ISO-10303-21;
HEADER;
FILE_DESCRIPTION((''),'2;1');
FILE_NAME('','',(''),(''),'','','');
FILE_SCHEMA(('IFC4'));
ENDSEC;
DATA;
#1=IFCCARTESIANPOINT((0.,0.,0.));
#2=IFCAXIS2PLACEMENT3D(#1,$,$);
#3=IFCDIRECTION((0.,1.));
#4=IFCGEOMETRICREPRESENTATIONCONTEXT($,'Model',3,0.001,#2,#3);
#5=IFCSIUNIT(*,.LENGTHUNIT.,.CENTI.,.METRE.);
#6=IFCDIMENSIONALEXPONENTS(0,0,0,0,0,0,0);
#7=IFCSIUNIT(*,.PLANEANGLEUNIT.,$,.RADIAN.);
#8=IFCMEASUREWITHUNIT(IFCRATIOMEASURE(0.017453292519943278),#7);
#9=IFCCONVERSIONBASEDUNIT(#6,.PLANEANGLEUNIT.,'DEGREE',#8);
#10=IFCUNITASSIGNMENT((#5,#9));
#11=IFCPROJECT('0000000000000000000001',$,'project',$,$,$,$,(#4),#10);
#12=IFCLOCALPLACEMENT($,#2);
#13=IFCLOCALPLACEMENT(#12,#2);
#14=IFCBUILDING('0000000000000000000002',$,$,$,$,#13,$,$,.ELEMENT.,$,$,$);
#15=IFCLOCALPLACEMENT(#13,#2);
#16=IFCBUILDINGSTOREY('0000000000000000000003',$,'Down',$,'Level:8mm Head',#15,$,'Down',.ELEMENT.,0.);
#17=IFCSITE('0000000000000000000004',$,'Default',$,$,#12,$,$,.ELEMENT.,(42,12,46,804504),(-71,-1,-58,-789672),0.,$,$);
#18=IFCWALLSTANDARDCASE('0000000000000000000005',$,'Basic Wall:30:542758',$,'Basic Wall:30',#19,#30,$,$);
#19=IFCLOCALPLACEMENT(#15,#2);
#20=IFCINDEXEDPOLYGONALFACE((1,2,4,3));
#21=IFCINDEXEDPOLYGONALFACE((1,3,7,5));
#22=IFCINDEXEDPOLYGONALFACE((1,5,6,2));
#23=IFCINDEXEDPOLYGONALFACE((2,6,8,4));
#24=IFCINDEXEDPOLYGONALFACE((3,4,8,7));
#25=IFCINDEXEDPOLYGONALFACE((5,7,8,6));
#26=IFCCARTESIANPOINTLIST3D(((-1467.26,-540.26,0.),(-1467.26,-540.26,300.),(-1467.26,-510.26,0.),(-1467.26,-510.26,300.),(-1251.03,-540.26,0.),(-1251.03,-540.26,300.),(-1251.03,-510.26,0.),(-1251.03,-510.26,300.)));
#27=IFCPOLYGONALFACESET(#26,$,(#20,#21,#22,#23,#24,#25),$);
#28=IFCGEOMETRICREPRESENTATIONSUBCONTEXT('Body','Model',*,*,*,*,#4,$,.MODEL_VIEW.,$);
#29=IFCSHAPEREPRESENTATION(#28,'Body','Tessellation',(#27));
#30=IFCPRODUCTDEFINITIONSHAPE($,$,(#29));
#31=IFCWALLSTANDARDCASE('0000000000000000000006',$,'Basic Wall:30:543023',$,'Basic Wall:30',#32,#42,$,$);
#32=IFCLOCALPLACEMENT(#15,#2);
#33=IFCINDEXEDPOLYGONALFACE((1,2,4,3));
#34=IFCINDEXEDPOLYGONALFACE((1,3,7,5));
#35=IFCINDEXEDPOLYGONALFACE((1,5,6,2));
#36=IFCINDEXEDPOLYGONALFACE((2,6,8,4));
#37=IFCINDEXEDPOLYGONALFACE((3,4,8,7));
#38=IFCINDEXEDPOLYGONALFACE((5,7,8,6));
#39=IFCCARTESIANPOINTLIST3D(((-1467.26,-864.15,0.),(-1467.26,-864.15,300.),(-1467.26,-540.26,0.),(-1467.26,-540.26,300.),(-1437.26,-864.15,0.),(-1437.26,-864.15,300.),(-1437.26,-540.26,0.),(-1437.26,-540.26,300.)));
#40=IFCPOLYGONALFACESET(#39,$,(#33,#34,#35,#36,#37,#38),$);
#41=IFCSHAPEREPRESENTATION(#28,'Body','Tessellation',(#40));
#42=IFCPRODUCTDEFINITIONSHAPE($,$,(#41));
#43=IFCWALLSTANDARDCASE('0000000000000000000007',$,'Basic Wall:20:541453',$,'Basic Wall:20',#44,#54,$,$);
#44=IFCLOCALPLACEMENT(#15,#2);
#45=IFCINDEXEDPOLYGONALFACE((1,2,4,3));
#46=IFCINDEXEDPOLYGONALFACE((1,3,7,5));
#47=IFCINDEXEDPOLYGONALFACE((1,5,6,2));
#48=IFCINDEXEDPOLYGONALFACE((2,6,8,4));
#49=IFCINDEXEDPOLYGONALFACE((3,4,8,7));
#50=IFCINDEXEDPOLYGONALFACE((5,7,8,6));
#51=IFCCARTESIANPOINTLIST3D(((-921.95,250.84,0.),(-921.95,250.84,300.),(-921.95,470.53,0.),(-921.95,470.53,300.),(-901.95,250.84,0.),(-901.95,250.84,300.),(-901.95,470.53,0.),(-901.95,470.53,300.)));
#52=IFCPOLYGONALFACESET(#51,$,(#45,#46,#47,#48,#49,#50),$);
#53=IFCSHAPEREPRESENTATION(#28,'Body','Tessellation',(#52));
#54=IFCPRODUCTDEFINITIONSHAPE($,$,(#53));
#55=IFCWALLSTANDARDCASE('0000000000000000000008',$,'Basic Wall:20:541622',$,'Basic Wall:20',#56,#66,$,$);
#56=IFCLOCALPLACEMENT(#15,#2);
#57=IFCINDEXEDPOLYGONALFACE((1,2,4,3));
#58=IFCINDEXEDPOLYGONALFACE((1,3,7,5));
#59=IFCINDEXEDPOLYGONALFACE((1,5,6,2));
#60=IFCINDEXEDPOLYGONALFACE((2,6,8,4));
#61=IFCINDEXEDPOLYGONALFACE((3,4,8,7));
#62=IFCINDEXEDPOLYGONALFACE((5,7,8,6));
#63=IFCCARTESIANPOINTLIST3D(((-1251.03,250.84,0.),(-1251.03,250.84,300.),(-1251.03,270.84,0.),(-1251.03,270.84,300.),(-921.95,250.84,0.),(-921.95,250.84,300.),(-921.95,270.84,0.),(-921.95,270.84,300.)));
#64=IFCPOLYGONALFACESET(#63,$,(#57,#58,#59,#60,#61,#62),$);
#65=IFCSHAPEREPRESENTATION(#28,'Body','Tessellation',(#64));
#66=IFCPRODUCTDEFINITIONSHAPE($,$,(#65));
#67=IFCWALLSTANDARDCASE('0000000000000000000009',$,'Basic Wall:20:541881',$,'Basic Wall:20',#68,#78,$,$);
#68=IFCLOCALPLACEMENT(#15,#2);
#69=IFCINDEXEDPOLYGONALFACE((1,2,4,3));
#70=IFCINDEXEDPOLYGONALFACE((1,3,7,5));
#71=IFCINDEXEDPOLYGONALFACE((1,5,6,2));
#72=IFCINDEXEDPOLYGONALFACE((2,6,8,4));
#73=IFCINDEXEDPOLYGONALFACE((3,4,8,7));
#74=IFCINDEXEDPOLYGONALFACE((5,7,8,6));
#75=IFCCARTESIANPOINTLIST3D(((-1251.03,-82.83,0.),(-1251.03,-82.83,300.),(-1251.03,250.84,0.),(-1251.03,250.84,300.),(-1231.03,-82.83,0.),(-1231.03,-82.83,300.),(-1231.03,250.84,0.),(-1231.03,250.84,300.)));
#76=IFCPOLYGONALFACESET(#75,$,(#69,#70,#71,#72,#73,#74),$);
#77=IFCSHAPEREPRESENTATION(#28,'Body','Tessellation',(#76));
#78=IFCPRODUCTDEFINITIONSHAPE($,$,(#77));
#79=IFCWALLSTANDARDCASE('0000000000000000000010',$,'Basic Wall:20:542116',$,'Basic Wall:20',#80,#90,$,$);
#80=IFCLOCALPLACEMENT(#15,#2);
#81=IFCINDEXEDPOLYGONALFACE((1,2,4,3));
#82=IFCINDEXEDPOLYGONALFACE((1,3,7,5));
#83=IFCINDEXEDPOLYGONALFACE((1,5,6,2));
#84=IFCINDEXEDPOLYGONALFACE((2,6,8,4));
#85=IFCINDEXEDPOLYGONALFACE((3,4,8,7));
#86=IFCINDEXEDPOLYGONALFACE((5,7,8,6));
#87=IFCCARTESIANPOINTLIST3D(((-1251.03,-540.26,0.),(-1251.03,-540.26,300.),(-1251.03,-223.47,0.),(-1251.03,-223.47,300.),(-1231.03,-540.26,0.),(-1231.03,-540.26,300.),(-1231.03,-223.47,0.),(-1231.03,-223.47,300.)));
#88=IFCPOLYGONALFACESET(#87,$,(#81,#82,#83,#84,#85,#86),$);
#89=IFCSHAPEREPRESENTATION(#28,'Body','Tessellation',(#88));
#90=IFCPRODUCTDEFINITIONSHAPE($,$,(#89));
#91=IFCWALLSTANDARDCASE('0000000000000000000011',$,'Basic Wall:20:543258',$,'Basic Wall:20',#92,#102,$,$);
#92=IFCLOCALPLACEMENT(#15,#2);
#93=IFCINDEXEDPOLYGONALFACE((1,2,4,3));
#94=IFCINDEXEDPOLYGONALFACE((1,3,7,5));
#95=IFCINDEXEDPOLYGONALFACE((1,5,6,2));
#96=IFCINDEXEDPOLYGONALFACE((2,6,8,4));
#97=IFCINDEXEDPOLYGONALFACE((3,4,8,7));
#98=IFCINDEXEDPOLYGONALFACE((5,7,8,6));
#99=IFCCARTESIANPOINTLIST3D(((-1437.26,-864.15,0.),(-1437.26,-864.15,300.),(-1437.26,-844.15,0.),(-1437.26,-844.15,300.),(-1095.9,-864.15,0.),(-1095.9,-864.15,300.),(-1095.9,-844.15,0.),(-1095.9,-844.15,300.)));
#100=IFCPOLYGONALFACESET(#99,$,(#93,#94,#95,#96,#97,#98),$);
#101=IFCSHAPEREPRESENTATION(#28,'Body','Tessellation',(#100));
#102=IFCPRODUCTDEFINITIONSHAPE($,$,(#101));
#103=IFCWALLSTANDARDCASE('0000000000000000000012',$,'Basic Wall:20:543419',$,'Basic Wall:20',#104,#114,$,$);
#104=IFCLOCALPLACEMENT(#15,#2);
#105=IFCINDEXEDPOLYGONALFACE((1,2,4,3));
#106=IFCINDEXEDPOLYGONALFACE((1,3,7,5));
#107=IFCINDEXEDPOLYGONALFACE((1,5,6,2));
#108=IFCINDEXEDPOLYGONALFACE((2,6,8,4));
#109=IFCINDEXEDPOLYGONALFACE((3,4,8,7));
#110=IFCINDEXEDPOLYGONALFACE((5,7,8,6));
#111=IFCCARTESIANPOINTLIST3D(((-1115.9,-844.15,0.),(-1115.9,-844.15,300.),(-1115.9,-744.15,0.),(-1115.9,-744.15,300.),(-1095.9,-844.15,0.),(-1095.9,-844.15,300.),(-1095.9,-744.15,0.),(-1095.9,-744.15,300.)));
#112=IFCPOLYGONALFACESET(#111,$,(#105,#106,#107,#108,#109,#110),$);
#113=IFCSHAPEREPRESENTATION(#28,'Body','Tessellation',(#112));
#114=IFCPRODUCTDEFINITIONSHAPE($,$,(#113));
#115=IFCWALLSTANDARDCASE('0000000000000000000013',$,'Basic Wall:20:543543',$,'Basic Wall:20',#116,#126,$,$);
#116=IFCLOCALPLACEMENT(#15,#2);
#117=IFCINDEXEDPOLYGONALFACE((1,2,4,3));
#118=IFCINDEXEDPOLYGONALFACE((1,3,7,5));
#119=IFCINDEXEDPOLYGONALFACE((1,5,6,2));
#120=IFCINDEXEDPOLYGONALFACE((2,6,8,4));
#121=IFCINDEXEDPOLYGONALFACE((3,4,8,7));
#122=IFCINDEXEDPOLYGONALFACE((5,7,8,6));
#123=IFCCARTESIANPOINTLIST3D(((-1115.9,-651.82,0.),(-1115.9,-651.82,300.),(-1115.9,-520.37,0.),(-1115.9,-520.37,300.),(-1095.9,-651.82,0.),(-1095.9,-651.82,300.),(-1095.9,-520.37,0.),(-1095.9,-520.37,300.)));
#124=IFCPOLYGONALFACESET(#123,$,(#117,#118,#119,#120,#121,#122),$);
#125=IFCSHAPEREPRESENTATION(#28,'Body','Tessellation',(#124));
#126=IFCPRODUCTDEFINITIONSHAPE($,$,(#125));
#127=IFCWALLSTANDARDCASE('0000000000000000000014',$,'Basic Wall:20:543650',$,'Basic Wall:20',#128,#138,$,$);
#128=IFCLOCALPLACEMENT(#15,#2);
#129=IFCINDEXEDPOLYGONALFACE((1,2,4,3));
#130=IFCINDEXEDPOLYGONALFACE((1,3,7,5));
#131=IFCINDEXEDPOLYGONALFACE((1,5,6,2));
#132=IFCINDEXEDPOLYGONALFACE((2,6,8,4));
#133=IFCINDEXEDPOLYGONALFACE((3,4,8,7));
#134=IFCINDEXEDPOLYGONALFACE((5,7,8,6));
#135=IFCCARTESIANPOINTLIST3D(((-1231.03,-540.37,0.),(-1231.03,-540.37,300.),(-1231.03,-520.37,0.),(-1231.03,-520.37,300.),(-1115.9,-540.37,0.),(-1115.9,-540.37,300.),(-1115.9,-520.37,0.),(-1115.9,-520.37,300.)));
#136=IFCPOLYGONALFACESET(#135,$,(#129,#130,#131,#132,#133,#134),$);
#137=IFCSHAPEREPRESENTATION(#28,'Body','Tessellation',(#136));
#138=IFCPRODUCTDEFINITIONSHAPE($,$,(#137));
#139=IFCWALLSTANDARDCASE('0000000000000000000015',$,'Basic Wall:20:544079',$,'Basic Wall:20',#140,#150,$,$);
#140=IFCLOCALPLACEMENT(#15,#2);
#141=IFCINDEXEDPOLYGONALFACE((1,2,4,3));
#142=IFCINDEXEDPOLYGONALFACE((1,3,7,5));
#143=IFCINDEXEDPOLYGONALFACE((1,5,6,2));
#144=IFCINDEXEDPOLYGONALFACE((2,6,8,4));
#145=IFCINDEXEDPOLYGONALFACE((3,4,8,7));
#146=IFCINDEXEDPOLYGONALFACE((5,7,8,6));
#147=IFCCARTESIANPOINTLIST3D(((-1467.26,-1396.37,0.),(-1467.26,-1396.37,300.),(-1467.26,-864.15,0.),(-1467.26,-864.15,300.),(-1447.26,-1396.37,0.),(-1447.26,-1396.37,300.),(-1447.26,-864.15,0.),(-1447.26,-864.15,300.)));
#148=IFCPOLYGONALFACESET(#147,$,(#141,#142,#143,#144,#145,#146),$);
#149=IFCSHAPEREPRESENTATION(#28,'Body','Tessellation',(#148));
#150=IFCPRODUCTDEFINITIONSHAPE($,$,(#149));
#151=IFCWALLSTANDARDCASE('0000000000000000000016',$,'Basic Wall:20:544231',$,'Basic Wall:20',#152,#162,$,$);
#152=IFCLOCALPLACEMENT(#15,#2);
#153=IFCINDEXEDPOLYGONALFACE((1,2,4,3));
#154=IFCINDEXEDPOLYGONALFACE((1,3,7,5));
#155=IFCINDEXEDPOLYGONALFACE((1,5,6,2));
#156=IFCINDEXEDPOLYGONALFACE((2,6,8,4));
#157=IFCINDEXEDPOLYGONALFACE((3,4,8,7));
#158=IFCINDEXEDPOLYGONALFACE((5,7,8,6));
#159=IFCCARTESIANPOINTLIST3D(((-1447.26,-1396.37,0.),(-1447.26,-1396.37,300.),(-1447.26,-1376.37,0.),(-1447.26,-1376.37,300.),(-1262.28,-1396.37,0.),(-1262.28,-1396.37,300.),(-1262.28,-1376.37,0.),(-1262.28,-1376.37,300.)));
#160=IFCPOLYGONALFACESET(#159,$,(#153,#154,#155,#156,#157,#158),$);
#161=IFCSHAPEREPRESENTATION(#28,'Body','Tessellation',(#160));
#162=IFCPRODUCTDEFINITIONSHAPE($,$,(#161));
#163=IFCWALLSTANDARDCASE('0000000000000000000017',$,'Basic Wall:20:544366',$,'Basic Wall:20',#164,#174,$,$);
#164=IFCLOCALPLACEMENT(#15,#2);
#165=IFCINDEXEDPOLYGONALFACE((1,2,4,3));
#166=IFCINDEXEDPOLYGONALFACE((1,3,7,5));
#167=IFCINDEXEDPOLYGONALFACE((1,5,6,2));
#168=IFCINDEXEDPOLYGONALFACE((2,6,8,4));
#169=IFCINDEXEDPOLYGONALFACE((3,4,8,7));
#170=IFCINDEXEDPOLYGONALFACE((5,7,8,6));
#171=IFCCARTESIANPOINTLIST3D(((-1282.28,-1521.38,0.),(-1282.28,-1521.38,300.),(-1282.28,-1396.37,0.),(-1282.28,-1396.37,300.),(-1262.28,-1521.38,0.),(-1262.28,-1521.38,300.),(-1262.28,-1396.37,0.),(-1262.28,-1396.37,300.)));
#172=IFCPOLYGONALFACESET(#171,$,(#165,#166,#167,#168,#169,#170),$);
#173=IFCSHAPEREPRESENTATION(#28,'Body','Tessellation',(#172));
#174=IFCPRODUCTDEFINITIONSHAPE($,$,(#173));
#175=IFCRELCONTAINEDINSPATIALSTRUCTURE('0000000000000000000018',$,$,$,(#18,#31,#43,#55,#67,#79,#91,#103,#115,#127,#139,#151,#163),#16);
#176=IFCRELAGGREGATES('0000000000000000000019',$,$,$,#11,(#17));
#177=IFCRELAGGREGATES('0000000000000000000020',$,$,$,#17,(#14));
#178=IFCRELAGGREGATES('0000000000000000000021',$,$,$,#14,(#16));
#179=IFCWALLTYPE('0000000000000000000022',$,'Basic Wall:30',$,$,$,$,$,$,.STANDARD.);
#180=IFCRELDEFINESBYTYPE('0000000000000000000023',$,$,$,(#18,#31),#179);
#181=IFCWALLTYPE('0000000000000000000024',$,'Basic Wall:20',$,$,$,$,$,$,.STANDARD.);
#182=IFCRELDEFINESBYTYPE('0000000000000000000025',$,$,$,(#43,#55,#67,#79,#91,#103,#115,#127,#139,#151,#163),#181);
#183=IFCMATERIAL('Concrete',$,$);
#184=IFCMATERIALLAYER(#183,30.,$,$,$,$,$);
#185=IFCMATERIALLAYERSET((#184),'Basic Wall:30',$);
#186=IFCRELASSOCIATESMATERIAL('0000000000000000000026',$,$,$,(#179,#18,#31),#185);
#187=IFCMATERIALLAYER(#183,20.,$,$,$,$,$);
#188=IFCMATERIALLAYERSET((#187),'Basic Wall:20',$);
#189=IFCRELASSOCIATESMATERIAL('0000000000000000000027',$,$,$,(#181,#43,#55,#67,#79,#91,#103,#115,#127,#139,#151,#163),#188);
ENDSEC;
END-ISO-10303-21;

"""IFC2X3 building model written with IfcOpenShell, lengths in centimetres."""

from ifc_helpers import new_model, entity, si_unit, converted_unit, direction, frame, frame_2d, origin, place, context, subcontext, project, spatial, rectangle, extrude, material, layer, layer_set, layer_usage, type_object, element, save


model = new_model("IFC2X3")

# Units and contexts
model_context = context("Model", 3, precision=0.001, world=origin(), true_north=direction((0.0, 1.0)))
body_context = subcontext(model_context, "Body", "Model", "MODEL_VIEW")
ifc_project = project(units=[si_unit("LENGTHUNIT", "METRE", prefix="CENTI"), converted_unit("PLANEANGLEUNIT", "DEGREE", entity("IfcRatioMeasure", 0.017453292519943278), si_unit("PLANEANGLEUNIT", "RADIAN"), dimensions=[0, 0, 0, 0, 0, 0, 0])], contexts=[model_context])

# Site, building, storey
site_placement = place(None, origin())
site = spatial("IfcSite", under=ifc_project, at=site_placement, Name="Default", CompositionType="ELEMENT", RefLatitude=(42, 12, 46, 804504), RefLongitude=(-71, -1, -58, -789672), RefElevation=0.0)
building_placement = place(site_placement, origin())
building = spatial("IfcBuilding", under=site, at=building_placement, CompositionType="ELEMENT")
storey_placement = place(building_placement, origin())
storey = spatial("IfcBuildingStorey", under=building, at=storey_placement, Name="Down", ObjectType="Level:8mm Head", LongName="Down", CompositionType="ELEMENT", Elevation=0.0)

# Walls
ifc_material = material(Name="Concrete")
ifc_layer_1 = layer(ifc_material, 30.0)
ifc_layer_set_1 = layer_set([ifc_layer_1], Name="Basic Wall:30")
ifc_layer_usage_1 = layer_usage(ifc_layer_set_1, "AXIS2", "NEGATIVE", 15.0)
wall_type_1 = type_object("IfcWallType", Name="Basic Wall:30", PredefinedType="STANDARD", material=ifc_layer_set_1)
wall_1_placement = place(storey_placement, frame((-1467.26, -525.26, 0.0)))
element("IfcWallStandardCase", 1, at=wall_1_placement, inside=storey, type_object=wall_type_1, material=ifc_layer_usage_1, Name="Basic Wall:30:542758", ObjectType="Basic Wall:30", context=body_context, shape_type="SweptSolid", body=[
    extrude(rectangle(XDim=216.23, YDim=30.0, at=frame_2d((108.12, 0.0), x_axis=(-1.0, 0.0))), origin(), (0.0, 0.0, 1.0), 300.0),
])
ifc_layer_usage_2 = layer_usage(ifc_layer_set_1, "AXIS2", "POSITIVE", -15.0)
wall_2_placement = place(storey_placement, frame((-1452.26, -540.26, 0.0), z_axis=(0.0, 0.0, 1.0), x_axis=(0.0, -1.0, 0.0)))
element("IfcWallStandardCase", 2, at=wall_2_placement, inside=storey, type_object=wall_type_1, material=ifc_layer_usage_2, Name="Basic Wall:30:543023", ObjectType="Basic Wall:30", context=body_context, shape_type="SweptSolid", body=[
    extrude(rectangle(XDim=323.89, YDim=30.0, at=frame_2d((161.95, 0.0), x_axis=(-1.0, 0.0))), origin(), (0.0, 0.0, 1.0), 300.0),
])
ifc_layer_2 = layer(ifc_material, 20.0)
ifc_layer_set_2 = layer_set([ifc_layer_2], Name="Basic Wall:20")
ifc_layer_usage_3 = layer_usage(ifc_layer_set_2, "AXIS2", "NEGATIVE", 10.0)
wall_type_2 = type_object("IfcWallType", Name="Basic Wall:20", PredefinedType="STANDARD", material=ifc_layer_set_2)
wall_3_placement = place(storey_placement, frame((-911.95, 470.53, 0.0), z_axis=(0.0, 0.0, 1.0), x_axis=(0.0, -1.0, 0.0)))
element("IfcWallStandardCase", 3, at=wall_3_placement, inside=storey, type_object=wall_type_2, material=ifc_layer_usage_3, Name="Basic Wall:20:541453", ObjectType="Basic Wall:20", context=body_context, shape_type="SweptSolid", body=[
    extrude(rectangle(XDim=219.69, YDim=20.0, at=frame_2d((109.84, 0.0), x_axis=(-1.0, 0.0))), origin(), (0.0, 0.0, 1.0), 300.0),
])
ifc_layer_usage_4 = layer_usage(ifc_layer_set_2, "AXIS2", "NEGATIVE", 10.0)
wall_4_placement = place(storey_placement, frame((-921.95, 260.84, 0.0), z_axis=(0.0, 0.0, 1.0), x_axis=(-1.0, 0.0, 0.0)))
element("IfcWallStandardCase", 4, at=wall_4_placement, inside=storey, type_object=wall_type_2, material=ifc_layer_usage_4, Name="Basic Wall:20:541622", ObjectType="Basic Wall:20", context=body_context, shape_type="SweptSolid", body=[
    extrude(rectangle(XDim=329.07, YDim=20.0, at=frame_2d((164.54, 0.0), x_axis=(-1.0, 0.0))), origin(), (0.0, 0.0, 1.0), 300.0),
])
ifc_layer_usage_5 = layer_usage(ifc_layer_set_2, "AXIS2", "POSITIVE", -10.0)
wall_5_placement = place(storey_placement, frame((-1241.03, 250.84, 0.0), z_axis=(0.0, 0.0, 1.0), x_axis=(0.0, -1.0, 0.0)))
element("IfcWallStandardCase", 5, at=wall_5_placement, inside=storey, type_object=wall_type_2, material=ifc_layer_usage_5, Name="Basic Wall:20:541881", ObjectType="Basic Wall:20", context=body_context, shape_type="SweptSolid", body=[
    extrude(rectangle(XDim=333.67, YDim=20.0, at=frame_2d((166.84, 0.0), x_axis=(-1.0, 0.0))), origin(), (0.0, 0.0, 1.0), 300.0),
])
ifc_layer_usage_6 = layer_usage(ifc_layer_set_2, "AXIS2", "POSITIVE", -10.0)
wall_6_placement = place(storey_placement, frame((-1241.03, -223.47, 0.0), z_axis=(0.0, 0.0, 1.0), x_axis=(0.0, -1.0, 0.0)))
element("IfcWallStandardCase", 6, at=wall_6_placement, inside=storey, type_object=wall_type_2, material=ifc_layer_usage_6, Name="Basic Wall:20:542116", ObjectType="Basic Wall:20", context=body_context, shape_type="SweptSolid", body=[
    extrude(rectangle(XDim=316.79, YDim=20.0, at=frame_2d((158.4, 0.0), x_axis=(-1.0, 0.0))), origin(), (0.0, 0.0, 1.0), 300.0),
])
ifc_layer_usage_7 = layer_usage(ifc_layer_set_2, "AXIS2", "POSITIVE", -10.0)
wall_7_placement = place(storey_placement, frame((-1437.26, -854.15, 0.0)))
element("IfcWallStandardCase", 7, at=wall_7_placement, inside=storey, type_object=wall_type_2, material=ifc_layer_usage_7, Name="Basic Wall:20:543258", ObjectType="Basic Wall:20", context=body_context, shape_type="SweptSolid", body=[
    extrude(rectangle(XDim=341.36, YDim=20.0, at=frame_2d((170.68, 0.0), x_axis=(-1.0, 0.0))), origin(), (0.0, 0.0, 1.0), 300.0),
])
ifc_layer_usage_8 = layer_usage(ifc_layer_set_2, "AXIS2", "POSITIVE", -10.0)
wall_8_placement = place(storey_placement, frame((-1105.9, -844.15, 0.0), z_axis=(0.0, 0.0, 1.0), x_axis=(0.0, 1.0, 0.0)))
element("IfcWallStandardCase", 8, at=wall_8_placement, inside=storey, type_object=wall_type_2, material=ifc_layer_usage_8, Name="Basic Wall:20:543419", ObjectType="Basic Wall:20", context=body_context, shape_type="SweptSolid", body=[
    extrude(rectangle(XDim=100.0, YDim=20.0, at=frame_2d((50.0, 0.0), x_axis=(-1.0, 0.0))), origin(), (0.0, 0.0, 1.0), 300.0),
])
ifc_layer_usage_9 = layer_usage(ifc_layer_set_2, "AXIS2", "POSITIVE", -10.0)
wall_9_placement = place(storey_placement, frame((-1105.9, -651.82, 0.0), z_axis=(0.0, 0.0, 1.0), x_axis=(0.0, 1.0, 0.0)))
element("IfcWallStandardCase", 9, at=wall_9_placement, inside=storey, type_object=wall_type_2, material=ifc_layer_usage_9, Name="Basic Wall:20:543543", ObjectType="Basic Wall:20", context=body_context, shape_type="SweptSolid", body=[
    extrude(rectangle(XDim=131.45, YDim=20.0, at=frame_2d((65.72, 0.0), x_axis=(-1.0, 0.0))), origin(), (0.0, 0.0, 1.0), 300.0),
])
ifc_layer_usage_10 = layer_usage(ifc_layer_set_2, "AXIS2", "POSITIVE", -10.0)
wall_10_placement = place(storey_placement, frame((-1115.9, -530.37, 0.0), z_axis=(0.0, 0.0, 1.0), x_axis=(-1.0, 0.0, 0.0)))
element("IfcWallStandardCase", 10, at=wall_10_placement, inside=storey, type_object=wall_type_2, material=ifc_layer_usage_10, Name="Basic Wall:20:543650", ObjectType="Basic Wall:20", context=body_context, shape_type="SweptSolid", body=[
    extrude(rectangle(XDim=115.12, YDim=20.0, at=frame_2d((57.56, 0.0), x_axis=(-1.0, 0.0))), origin(), (0.0, 0.0, 1.0), 300.0),
])
ifc_layer_usage_11 = layer_usage(ifc_layer_set_2, "AXIS2", "POSITIVE", -10.0)
wall_11_placement = place(storey_placement, frame((-1457.26, -864.15, 0.0), z_axis=(0.0, 0.0, 1.0), x_axis=(0.0, -1.0, 0.0)))
element("IfcWallStandardCase", 11, at=wall_11_placement, inside=storey, type_object=wall_type_2, material=ifc_layer_usage_11, Name="Basic Wall:20:544079", ObjectType="Basic Wall:20", context=body_context, shape_type="SweptSolid", body=[
    extrude(rectangle(XDim=532.22, YDim=20.0, at=frame_2d((266.11, 0.0), x_axis=(-1.0, 0.0))), origin(), (0.0, 0.0, 1.0), 300.0),
])
ifc_layer_usage_12 = layer_usage(ifc_layer_set_2, "AXIS2", "POSITIVE", -10.0)
wall_12_placement = place(storey_placement, frame((-1447.26, -1386.37, 0.0)))
element("IfcWallStandardCase", 12, at=wall_12_placement, inside=storey, type_object=wall_type_2, material=ifc_layer_usage_12, Name="Basic Wall:20:544231", ObjectType="Basic Wall:20", context=body_context, shape_type="SweptSolid", body=[
    extrude(rectangle(XDim=184.98, YDim=20.0, at=frame_2d((92.49, 0.0), x_axis=(-1.0, 0.0))), origin(), (0.0, 0.0, 1.0), 300.0),
])
ifc_layer_usage_13 = layer_usage(ifc_layer_set_2, "AXIS2", "NEGATIVE", 10.0)
wall_13_placement = place(storey_placement, frame((-1272.28, -1396.37, 0.0), z_axis=(0.0, 0.0, 1.0), x_axis=(0.0, -1.0, 0.0)))
element("IfcWallStandardCase", 13, at=wall_13_placement, inside=storey, type_object=wall_type_2, material=ifc_layer_usage_13, Name="Basic Wall:20:544366", ObjectType="Basic Wall:20", context=body_context, shape_type="SweptSolid", body=[
    extrude(rectangle(XDim=125.01, YDim=20.0, at=frame_2d((62.51, 0.0), x_axis=(-1.0, 0.0))), origin(), (0.0, 0.0, 1.0), 300.0),
])

save(model, "model.ifc")
